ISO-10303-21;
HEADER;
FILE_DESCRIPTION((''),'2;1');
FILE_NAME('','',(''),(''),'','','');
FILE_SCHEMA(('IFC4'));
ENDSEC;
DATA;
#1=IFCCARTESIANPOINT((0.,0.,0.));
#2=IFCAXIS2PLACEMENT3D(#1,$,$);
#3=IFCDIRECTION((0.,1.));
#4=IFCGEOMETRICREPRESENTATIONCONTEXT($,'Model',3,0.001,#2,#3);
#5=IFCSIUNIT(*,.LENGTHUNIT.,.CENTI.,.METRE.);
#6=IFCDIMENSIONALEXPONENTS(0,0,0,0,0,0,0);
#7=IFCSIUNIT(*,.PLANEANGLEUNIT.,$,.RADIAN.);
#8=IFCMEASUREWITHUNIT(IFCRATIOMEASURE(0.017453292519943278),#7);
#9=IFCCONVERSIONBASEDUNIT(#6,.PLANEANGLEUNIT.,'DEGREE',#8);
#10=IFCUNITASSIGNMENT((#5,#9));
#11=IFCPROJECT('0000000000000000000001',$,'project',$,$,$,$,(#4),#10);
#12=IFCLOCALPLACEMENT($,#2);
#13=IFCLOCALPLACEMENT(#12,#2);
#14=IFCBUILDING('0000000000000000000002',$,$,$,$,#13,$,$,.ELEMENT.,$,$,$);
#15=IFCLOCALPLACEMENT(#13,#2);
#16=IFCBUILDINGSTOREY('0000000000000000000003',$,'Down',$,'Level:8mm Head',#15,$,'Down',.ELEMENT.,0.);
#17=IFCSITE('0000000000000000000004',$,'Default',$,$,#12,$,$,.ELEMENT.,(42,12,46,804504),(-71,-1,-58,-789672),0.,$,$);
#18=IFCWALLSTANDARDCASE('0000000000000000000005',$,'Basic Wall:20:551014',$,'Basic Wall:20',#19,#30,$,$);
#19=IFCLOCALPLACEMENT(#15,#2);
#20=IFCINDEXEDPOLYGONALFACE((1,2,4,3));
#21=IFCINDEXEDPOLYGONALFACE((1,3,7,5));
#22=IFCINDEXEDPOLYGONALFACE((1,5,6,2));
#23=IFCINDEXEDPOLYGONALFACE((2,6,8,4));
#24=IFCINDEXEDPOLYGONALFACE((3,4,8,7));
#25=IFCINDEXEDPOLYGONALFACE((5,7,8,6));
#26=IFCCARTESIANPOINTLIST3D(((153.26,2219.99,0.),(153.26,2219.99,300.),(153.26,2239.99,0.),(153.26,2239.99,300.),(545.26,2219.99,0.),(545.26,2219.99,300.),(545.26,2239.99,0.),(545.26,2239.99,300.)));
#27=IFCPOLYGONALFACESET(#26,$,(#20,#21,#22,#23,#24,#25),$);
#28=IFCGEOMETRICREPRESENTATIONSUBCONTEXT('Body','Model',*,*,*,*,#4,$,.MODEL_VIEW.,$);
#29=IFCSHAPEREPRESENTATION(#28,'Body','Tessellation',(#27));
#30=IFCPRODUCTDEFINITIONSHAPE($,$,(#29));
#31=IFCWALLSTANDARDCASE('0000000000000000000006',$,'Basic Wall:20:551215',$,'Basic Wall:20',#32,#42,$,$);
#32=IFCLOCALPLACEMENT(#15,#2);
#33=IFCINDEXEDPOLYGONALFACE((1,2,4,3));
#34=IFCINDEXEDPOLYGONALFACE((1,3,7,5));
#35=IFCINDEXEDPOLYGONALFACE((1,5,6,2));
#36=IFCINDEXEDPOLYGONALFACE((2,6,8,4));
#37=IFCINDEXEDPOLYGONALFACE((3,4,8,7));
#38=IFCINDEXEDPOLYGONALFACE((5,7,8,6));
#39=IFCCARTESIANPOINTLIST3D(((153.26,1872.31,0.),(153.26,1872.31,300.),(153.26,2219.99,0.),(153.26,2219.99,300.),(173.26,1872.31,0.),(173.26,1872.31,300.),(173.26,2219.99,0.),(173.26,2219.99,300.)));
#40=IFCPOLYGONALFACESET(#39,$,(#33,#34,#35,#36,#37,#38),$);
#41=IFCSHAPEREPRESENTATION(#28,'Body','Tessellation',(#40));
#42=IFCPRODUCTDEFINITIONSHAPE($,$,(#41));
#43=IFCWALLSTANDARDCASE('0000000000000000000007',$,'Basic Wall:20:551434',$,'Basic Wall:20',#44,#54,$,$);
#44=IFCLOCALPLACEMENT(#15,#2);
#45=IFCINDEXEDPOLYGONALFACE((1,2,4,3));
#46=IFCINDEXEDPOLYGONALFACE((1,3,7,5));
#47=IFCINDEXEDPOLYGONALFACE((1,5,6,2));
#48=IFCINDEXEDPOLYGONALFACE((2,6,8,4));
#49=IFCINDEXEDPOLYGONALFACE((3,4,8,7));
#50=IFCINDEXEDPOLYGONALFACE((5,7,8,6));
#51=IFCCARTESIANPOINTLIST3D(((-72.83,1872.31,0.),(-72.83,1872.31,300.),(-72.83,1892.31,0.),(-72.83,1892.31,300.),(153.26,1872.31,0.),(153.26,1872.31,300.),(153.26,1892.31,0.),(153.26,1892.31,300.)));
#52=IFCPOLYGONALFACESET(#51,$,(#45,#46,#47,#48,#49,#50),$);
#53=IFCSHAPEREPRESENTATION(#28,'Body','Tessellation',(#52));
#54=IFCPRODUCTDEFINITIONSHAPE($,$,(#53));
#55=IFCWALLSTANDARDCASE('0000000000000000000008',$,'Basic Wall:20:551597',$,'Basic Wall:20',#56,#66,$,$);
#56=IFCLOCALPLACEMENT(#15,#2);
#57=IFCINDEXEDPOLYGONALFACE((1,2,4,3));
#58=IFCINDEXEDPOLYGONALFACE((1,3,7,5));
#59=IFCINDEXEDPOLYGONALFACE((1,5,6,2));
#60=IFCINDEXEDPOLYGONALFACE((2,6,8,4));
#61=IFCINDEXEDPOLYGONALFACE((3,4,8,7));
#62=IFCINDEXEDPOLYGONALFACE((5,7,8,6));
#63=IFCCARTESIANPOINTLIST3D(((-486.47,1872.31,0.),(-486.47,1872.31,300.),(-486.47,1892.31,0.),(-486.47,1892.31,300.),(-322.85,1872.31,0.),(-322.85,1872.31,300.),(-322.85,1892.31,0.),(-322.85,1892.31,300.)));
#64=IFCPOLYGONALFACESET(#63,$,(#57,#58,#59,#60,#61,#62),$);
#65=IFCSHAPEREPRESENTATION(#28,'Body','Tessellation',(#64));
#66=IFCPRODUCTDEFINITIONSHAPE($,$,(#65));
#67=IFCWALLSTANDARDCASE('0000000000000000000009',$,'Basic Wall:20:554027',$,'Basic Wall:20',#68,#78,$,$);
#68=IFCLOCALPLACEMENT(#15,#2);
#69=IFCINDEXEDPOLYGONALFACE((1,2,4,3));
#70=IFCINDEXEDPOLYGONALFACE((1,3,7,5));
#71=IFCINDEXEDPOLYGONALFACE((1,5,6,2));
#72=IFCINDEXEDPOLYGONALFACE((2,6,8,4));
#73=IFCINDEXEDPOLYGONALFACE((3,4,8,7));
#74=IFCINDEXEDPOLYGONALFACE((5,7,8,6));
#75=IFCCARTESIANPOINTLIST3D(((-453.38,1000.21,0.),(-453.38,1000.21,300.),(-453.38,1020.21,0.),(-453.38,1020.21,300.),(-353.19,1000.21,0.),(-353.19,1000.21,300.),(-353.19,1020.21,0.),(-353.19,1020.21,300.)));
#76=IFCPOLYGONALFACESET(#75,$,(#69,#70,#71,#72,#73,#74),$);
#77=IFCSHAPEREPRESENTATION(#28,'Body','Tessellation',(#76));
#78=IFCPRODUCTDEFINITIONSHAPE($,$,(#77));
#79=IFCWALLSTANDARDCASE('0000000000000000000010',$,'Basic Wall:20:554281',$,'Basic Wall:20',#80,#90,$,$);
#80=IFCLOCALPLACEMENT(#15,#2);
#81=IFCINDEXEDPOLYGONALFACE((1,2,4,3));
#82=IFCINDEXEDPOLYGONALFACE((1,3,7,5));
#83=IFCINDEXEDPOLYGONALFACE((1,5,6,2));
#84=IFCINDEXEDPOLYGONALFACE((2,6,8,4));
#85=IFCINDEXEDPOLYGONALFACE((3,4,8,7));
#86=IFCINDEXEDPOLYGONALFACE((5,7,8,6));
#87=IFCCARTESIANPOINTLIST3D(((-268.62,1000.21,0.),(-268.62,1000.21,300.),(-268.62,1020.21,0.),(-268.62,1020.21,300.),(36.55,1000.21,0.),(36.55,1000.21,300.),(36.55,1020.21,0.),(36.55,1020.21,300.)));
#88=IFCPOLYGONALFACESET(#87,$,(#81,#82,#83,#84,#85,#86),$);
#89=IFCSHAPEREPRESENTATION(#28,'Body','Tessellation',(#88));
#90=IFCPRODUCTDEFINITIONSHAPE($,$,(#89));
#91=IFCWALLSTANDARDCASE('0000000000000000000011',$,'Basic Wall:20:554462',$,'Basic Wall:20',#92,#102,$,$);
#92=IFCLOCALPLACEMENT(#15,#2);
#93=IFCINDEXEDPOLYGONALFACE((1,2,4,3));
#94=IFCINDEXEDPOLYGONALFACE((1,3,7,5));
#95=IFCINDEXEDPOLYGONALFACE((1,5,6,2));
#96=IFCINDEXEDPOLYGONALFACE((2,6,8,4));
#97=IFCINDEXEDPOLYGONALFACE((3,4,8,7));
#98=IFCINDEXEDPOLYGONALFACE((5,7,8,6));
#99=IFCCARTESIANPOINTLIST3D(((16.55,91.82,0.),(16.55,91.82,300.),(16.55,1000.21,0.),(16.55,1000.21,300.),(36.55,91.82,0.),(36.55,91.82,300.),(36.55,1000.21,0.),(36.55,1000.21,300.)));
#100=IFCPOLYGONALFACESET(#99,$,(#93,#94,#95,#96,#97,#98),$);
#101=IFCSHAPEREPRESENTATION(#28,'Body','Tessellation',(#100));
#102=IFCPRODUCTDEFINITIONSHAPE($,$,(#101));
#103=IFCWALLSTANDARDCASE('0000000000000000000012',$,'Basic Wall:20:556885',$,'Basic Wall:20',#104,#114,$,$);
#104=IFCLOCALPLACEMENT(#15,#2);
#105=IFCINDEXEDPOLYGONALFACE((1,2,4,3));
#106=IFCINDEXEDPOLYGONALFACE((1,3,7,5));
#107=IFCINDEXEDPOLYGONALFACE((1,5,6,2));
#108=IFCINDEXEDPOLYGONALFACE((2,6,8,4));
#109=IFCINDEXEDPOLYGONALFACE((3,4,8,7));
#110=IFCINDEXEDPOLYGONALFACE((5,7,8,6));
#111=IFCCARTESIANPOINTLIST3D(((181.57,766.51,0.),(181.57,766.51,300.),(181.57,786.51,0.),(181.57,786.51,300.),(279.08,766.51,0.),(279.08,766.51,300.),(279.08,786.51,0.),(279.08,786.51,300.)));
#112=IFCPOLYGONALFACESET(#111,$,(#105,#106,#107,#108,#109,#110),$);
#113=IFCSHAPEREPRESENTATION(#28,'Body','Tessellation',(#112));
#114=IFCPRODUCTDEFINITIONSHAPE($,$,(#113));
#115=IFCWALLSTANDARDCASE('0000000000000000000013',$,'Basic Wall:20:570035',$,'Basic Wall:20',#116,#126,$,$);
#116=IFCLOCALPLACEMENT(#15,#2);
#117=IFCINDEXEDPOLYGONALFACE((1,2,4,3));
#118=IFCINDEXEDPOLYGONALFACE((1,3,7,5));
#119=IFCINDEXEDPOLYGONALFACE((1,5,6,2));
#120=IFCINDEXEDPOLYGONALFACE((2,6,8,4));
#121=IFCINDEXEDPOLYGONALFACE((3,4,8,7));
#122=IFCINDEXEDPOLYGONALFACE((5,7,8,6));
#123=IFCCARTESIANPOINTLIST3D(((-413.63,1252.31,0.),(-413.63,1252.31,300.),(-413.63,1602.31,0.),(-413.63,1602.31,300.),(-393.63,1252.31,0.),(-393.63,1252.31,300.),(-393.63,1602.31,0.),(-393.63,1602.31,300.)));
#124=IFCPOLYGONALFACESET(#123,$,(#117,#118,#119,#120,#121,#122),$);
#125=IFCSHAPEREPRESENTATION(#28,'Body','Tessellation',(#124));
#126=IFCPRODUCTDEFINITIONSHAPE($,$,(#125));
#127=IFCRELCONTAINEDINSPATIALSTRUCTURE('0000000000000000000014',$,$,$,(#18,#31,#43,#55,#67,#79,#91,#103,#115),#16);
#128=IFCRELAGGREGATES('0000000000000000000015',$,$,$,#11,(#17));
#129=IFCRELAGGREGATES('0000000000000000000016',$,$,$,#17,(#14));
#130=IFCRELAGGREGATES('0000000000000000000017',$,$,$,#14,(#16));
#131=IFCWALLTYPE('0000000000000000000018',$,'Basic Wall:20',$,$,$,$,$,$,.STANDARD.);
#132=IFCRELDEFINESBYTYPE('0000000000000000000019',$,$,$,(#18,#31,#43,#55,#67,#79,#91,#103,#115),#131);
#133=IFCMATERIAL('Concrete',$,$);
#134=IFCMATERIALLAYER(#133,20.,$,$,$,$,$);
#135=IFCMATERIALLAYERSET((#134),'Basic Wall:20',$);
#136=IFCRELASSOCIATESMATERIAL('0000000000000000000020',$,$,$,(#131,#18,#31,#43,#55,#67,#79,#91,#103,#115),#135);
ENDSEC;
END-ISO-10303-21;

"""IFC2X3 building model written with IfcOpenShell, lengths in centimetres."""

from ifc_helpers import new_model, entity, si_unit, converted_unit, direction, frame, frame_2d, origin, place, context, subcontext, project, spatial, rectangle, extrude, material, layer, layer_set, layer_usage, type_object, element, save


model = new_model("IFC2X3")

# Units and contexts
model_context = context("Model", 3, precision=0.001, world=origin(), true_north=direction((0.0, 1.0)))
body_context = subcontext(model_context, "Body", "Model", "MODEL_VIEW")
ifc_project = project(units=[si_unit("LENGTHUNIT", "METRE", prefix="CENTI"), converted_unit("PLANEANGLEUNIT", "DEGREE", entity("IfcRatioMeasure", 0.017453292519943278), si_unit("PLANEANGLEUNIT", "RADIAN"), dimensions=[0, 0, 0, 0, 0, 0, 0])], contexts=[model_context])

# Site, building, storey
site_placement = place(None, origin())
site = spatial("IfcSite", under=ifc_project, at=site_placement, Name="Default", CompositionType="ELEMENT", RefLatitude=(42, 12, 46, 804504), RefLongitude=(-71, -1, -58, -789672), RefElevation=0.0)
building_placement = place(site_placement, origin())
building = spatial("IfcBuilding", under=site, at=building_placement, CompositionType="ELEMENT")
storey_placement = place(building_placement, origin())
storey = spatial("IfcBuildingStorey", under=building, at=storey_placement, Name="Down", ObjectType="Level:8mm Head", LongName="Down", CompositionType="ELEMENT", Elevation=0.0)

# Walls
ifc_material = material(Name="Concrete")
ifc_layer_1 = layer(ifc_material, 20.0)
ifc_layer_set_1 = layer_set([ifc_layer_1], Name="Basic Wall:20")
wall_type_1 = type_object("IfcWallType", Name="Basic Wall:20", PredefinedType="STANDARD", material=ifc_layer_set_1)
ifc_layer_usage_1 = layer_usage(ifc_layer_set_1, "AXIS2", "POSITIVE", -10.0)
wall_1_placement = place(storey_placement, frame((545.26, 2229.99, 0.0), z_axis=(0.0, 0.0, 1.0), x_axis=(-1.0, 0.0, 0.0)))
element("IfcWallStandardCase", 1, at=wall_1_placement, inside=storey, type_object=wall_type_1, material=ifc_layer_usage_1, Name="Basic Wall:20:551014", ObjectType="Basic Wall:20", context=body_context, shape_type="SweptSolid", body=[
    extrude(rectangle(XDim=392.0, YDim=20.0, at=frame_2d((196.0, 0.0), x_axis=(-1.0, 0.0))), origin(), (0.0, 0.0, 1.0), 300.0),
])
ifc_layer_usage_2 = layer_usage(ifc_layer_set_1, "AXIS2", "POSITIVE", -10.0)
wall_2_placement = place(storey_placement, frame((163.26, 2219.99, 0.0), z_axis=(0.0, 0.0, 1.0), x_axis=(0.0, -1.0, 0.0)))
element("IfcWallStandardCase", 2, at=wall_2_placement, inside=storey, type_object=wall_type_1, material=ifc_layer_usage_2, Name="Basic Wall:20:551215", ObjectType="Basic Wall:20", context=body_context, shape_type="SweptSolid", body=[
    extrude(rectangle(XDim=347.68, YDim=20.0, at=frame_2d((173.84, 0.0), x_axis=(-1.0, 0.0))), origin(), (0.0, 0.0, 1.0), 300.0),
])
ifc_layer_usage_3 = layer_usage(ifc_layer_set_1, "AXIS2", "NEGATIVE", 10.0)
wall_3_placement = place(storey_placement, frame((153.26, 1882.31, 0.0), z_axis=(0.0, 0.0, 1.0), x_axis=(-1.0, 0.0, 0.0)))
element("IfcWallStandardCase", 3, at=wall_3_placement, inside=storey, type_object=wall_type_1, material=ifc_layer_usage_3, Name="Basic Wall:20:551434", ObjectType="Basic Wall:20", context=body_context, shape_type="SweptSolid", body=[
    extrude(rectangle(XDim=226.09, YDim=20.0, at=frame_2d((113.04, 0.0), x_axis=(-1.0, 0.0))), origin(), (0.0, 0.0, 1.0), 300.0),
])
ifc_layer_usage_4 = layer_usage(ifc_layer_set_1, "AXIS2", "NEGATIVE", 10.0)
wall_4_placement = place(storey_placement, frame((-322.85, 1882.31, 0.0), z_axis=(0.0, 0.0, 1.0), x_axis=(-1.0, 0.0, 0.0)))
element("IfcWallStandardCase", 4, at=wall_4_placement, inside=storey, type_object=wall_type_1, material=ifc_layer_usage_4, Name="Basic Wall:20:551597", ObjectType="Basic Wall:20", context=body_context, shape_type="SweptSolid", body=[
    extrude(rectangle(XDim=163.62, YDim=20.0, at=frame_2d((81.81, 0.0), x_axis=(-1.0, 0.0))), origin(), (0.0, 0.0, 1.0), 300.0),
])
ifc_layer_usage_5 = layer_usage(ifc_layer_set_1, "AXIS2", "NEGATIVE", 10.0)
wall_5_placement = place(storey_placement, frame((-453.38, 1010.21, 0.0)))
element("IfcWallStandardCase", 5, at=wall_5_placement, inside=storey, type_object=wall_type_1, material=ifc_layer_usage_5, Name="Basic Wall:20:554027", ObjectType="Basic Wall:20", context=body_context, shape_type="SweptSolid", body=[
    extrude(rectangle(XDim=100.19, YDim=20.0, at=frame_2d((50.1, 0.0), x_axis=(-1.0, 0.0))), origin(), (0.0, 0.0, 1.0), 300.0),
])
ifc_layer_usage_6 = layer_usage(ifc_layer_set_1, "AXIS2", "NEGATIVE", 10.0)
wall_6_placement = place(storey_placement, frame((-268.62, 1010.21, 0.0)))
element("IfcWallStandardCase", 6, at=wall_6_placement, inside=storey, type_object=wall_type_1, material=ifc_layer_usage_6, Name="Basic Wall:20:554281", ObjectType="Basic Wall:20", context=body_context, shape_type="SweptSolid", body=[
    extrude(rectangle(XDim=305.17, YDim=20.0, at=frame_2d((152.59, 0.0), x_axis=(-1.0, 0.0))), origin(), (0.0, 0.0, 1.0), 300.0),
])
ifc_layer_usage_7 = layer_usage(ifc_layer_set_1, "AXIS2", "NEGATIVE", 10.0)
wall_7_placement = place(storey_placement, frame((26.55, 1000.21, 0.0), z_axis=(0.0, 0.0, 1.0), x_axis=(0.0, -1.0, 0.0)))
element("IfcWallStandardCase", 7, at=wall_7_placement, inside=storey, type_object=wall_type_1, material=ifc_layer_usage_7, Name="Basic Wall:20:554462", ObjectType="Basic Wall:20", context=body_context, shape_type="SweptSolid", body=[
    extrude(rectangle(XDim=908.39, YDim=20.0, at=frame_2d((454.2, 0.0), x_axis=(-1.0, 0.0))), origin(), (0.0, 0.0, 1.0), 300.0),
])
ifc_layer_usage_8 = layer_usage(ifc_layer_set_1, "AXIS2", "NEGATIVE", 10.0)
wall_8_placement = place(storey_placement, frame((279.08, 776.51, 0.0), z_axis=(0.0, 0.0, 1.0), x_axis=(-1.0, 0.0, 0.0)))
element("IfcWallStandardCase", 8, at=wall_8_placement, inside=storey, type_object=wall_type_1, material=ifc_layer_usage_8, Name="Basic Wall:20:556885", ObjectType="Basic Wall:20", context=body_context, shape_type="SweptSolid", body=[
    extrude(rectangle(XDim=97.52, YDim=20.0, at=frame_2d((48.76, 0.0), x_axis=(-1.0, 0.0))), origin(), (0.0, 0.0, 1.0), 300.0),
])
ifc_layer_usage_9 = layer_usage(ifc_layer_set_1, "AXIS2", "NEGATIVE", 10.0)
wall_9_placement = place(storey_placement, frame((-403.63, 1602.31, 0.0), z_axis=(0.0, 0.0, 1.0), x_axis=(0.0, -1.0, 0.0)))
element("IfcWallStandardCase", 9, at=wall_9_placement, inside=storey, type_object=wall_type_1, material=ifc_layer_usage_9, Name="Basic Wall:20:570035", ObjectType="Basic Wall:20", context=body_context, shape_type="SweptSolid", body=[
    extrude(rectangle(XDim=350.0, YDim=20.0, at=frame_2d((175.0, 0.0), x_axis=(-1.0, 0.0))), origin(), (0.0, 0.0, 1.0), 300.0),
])

save(model, "model.ifc")
